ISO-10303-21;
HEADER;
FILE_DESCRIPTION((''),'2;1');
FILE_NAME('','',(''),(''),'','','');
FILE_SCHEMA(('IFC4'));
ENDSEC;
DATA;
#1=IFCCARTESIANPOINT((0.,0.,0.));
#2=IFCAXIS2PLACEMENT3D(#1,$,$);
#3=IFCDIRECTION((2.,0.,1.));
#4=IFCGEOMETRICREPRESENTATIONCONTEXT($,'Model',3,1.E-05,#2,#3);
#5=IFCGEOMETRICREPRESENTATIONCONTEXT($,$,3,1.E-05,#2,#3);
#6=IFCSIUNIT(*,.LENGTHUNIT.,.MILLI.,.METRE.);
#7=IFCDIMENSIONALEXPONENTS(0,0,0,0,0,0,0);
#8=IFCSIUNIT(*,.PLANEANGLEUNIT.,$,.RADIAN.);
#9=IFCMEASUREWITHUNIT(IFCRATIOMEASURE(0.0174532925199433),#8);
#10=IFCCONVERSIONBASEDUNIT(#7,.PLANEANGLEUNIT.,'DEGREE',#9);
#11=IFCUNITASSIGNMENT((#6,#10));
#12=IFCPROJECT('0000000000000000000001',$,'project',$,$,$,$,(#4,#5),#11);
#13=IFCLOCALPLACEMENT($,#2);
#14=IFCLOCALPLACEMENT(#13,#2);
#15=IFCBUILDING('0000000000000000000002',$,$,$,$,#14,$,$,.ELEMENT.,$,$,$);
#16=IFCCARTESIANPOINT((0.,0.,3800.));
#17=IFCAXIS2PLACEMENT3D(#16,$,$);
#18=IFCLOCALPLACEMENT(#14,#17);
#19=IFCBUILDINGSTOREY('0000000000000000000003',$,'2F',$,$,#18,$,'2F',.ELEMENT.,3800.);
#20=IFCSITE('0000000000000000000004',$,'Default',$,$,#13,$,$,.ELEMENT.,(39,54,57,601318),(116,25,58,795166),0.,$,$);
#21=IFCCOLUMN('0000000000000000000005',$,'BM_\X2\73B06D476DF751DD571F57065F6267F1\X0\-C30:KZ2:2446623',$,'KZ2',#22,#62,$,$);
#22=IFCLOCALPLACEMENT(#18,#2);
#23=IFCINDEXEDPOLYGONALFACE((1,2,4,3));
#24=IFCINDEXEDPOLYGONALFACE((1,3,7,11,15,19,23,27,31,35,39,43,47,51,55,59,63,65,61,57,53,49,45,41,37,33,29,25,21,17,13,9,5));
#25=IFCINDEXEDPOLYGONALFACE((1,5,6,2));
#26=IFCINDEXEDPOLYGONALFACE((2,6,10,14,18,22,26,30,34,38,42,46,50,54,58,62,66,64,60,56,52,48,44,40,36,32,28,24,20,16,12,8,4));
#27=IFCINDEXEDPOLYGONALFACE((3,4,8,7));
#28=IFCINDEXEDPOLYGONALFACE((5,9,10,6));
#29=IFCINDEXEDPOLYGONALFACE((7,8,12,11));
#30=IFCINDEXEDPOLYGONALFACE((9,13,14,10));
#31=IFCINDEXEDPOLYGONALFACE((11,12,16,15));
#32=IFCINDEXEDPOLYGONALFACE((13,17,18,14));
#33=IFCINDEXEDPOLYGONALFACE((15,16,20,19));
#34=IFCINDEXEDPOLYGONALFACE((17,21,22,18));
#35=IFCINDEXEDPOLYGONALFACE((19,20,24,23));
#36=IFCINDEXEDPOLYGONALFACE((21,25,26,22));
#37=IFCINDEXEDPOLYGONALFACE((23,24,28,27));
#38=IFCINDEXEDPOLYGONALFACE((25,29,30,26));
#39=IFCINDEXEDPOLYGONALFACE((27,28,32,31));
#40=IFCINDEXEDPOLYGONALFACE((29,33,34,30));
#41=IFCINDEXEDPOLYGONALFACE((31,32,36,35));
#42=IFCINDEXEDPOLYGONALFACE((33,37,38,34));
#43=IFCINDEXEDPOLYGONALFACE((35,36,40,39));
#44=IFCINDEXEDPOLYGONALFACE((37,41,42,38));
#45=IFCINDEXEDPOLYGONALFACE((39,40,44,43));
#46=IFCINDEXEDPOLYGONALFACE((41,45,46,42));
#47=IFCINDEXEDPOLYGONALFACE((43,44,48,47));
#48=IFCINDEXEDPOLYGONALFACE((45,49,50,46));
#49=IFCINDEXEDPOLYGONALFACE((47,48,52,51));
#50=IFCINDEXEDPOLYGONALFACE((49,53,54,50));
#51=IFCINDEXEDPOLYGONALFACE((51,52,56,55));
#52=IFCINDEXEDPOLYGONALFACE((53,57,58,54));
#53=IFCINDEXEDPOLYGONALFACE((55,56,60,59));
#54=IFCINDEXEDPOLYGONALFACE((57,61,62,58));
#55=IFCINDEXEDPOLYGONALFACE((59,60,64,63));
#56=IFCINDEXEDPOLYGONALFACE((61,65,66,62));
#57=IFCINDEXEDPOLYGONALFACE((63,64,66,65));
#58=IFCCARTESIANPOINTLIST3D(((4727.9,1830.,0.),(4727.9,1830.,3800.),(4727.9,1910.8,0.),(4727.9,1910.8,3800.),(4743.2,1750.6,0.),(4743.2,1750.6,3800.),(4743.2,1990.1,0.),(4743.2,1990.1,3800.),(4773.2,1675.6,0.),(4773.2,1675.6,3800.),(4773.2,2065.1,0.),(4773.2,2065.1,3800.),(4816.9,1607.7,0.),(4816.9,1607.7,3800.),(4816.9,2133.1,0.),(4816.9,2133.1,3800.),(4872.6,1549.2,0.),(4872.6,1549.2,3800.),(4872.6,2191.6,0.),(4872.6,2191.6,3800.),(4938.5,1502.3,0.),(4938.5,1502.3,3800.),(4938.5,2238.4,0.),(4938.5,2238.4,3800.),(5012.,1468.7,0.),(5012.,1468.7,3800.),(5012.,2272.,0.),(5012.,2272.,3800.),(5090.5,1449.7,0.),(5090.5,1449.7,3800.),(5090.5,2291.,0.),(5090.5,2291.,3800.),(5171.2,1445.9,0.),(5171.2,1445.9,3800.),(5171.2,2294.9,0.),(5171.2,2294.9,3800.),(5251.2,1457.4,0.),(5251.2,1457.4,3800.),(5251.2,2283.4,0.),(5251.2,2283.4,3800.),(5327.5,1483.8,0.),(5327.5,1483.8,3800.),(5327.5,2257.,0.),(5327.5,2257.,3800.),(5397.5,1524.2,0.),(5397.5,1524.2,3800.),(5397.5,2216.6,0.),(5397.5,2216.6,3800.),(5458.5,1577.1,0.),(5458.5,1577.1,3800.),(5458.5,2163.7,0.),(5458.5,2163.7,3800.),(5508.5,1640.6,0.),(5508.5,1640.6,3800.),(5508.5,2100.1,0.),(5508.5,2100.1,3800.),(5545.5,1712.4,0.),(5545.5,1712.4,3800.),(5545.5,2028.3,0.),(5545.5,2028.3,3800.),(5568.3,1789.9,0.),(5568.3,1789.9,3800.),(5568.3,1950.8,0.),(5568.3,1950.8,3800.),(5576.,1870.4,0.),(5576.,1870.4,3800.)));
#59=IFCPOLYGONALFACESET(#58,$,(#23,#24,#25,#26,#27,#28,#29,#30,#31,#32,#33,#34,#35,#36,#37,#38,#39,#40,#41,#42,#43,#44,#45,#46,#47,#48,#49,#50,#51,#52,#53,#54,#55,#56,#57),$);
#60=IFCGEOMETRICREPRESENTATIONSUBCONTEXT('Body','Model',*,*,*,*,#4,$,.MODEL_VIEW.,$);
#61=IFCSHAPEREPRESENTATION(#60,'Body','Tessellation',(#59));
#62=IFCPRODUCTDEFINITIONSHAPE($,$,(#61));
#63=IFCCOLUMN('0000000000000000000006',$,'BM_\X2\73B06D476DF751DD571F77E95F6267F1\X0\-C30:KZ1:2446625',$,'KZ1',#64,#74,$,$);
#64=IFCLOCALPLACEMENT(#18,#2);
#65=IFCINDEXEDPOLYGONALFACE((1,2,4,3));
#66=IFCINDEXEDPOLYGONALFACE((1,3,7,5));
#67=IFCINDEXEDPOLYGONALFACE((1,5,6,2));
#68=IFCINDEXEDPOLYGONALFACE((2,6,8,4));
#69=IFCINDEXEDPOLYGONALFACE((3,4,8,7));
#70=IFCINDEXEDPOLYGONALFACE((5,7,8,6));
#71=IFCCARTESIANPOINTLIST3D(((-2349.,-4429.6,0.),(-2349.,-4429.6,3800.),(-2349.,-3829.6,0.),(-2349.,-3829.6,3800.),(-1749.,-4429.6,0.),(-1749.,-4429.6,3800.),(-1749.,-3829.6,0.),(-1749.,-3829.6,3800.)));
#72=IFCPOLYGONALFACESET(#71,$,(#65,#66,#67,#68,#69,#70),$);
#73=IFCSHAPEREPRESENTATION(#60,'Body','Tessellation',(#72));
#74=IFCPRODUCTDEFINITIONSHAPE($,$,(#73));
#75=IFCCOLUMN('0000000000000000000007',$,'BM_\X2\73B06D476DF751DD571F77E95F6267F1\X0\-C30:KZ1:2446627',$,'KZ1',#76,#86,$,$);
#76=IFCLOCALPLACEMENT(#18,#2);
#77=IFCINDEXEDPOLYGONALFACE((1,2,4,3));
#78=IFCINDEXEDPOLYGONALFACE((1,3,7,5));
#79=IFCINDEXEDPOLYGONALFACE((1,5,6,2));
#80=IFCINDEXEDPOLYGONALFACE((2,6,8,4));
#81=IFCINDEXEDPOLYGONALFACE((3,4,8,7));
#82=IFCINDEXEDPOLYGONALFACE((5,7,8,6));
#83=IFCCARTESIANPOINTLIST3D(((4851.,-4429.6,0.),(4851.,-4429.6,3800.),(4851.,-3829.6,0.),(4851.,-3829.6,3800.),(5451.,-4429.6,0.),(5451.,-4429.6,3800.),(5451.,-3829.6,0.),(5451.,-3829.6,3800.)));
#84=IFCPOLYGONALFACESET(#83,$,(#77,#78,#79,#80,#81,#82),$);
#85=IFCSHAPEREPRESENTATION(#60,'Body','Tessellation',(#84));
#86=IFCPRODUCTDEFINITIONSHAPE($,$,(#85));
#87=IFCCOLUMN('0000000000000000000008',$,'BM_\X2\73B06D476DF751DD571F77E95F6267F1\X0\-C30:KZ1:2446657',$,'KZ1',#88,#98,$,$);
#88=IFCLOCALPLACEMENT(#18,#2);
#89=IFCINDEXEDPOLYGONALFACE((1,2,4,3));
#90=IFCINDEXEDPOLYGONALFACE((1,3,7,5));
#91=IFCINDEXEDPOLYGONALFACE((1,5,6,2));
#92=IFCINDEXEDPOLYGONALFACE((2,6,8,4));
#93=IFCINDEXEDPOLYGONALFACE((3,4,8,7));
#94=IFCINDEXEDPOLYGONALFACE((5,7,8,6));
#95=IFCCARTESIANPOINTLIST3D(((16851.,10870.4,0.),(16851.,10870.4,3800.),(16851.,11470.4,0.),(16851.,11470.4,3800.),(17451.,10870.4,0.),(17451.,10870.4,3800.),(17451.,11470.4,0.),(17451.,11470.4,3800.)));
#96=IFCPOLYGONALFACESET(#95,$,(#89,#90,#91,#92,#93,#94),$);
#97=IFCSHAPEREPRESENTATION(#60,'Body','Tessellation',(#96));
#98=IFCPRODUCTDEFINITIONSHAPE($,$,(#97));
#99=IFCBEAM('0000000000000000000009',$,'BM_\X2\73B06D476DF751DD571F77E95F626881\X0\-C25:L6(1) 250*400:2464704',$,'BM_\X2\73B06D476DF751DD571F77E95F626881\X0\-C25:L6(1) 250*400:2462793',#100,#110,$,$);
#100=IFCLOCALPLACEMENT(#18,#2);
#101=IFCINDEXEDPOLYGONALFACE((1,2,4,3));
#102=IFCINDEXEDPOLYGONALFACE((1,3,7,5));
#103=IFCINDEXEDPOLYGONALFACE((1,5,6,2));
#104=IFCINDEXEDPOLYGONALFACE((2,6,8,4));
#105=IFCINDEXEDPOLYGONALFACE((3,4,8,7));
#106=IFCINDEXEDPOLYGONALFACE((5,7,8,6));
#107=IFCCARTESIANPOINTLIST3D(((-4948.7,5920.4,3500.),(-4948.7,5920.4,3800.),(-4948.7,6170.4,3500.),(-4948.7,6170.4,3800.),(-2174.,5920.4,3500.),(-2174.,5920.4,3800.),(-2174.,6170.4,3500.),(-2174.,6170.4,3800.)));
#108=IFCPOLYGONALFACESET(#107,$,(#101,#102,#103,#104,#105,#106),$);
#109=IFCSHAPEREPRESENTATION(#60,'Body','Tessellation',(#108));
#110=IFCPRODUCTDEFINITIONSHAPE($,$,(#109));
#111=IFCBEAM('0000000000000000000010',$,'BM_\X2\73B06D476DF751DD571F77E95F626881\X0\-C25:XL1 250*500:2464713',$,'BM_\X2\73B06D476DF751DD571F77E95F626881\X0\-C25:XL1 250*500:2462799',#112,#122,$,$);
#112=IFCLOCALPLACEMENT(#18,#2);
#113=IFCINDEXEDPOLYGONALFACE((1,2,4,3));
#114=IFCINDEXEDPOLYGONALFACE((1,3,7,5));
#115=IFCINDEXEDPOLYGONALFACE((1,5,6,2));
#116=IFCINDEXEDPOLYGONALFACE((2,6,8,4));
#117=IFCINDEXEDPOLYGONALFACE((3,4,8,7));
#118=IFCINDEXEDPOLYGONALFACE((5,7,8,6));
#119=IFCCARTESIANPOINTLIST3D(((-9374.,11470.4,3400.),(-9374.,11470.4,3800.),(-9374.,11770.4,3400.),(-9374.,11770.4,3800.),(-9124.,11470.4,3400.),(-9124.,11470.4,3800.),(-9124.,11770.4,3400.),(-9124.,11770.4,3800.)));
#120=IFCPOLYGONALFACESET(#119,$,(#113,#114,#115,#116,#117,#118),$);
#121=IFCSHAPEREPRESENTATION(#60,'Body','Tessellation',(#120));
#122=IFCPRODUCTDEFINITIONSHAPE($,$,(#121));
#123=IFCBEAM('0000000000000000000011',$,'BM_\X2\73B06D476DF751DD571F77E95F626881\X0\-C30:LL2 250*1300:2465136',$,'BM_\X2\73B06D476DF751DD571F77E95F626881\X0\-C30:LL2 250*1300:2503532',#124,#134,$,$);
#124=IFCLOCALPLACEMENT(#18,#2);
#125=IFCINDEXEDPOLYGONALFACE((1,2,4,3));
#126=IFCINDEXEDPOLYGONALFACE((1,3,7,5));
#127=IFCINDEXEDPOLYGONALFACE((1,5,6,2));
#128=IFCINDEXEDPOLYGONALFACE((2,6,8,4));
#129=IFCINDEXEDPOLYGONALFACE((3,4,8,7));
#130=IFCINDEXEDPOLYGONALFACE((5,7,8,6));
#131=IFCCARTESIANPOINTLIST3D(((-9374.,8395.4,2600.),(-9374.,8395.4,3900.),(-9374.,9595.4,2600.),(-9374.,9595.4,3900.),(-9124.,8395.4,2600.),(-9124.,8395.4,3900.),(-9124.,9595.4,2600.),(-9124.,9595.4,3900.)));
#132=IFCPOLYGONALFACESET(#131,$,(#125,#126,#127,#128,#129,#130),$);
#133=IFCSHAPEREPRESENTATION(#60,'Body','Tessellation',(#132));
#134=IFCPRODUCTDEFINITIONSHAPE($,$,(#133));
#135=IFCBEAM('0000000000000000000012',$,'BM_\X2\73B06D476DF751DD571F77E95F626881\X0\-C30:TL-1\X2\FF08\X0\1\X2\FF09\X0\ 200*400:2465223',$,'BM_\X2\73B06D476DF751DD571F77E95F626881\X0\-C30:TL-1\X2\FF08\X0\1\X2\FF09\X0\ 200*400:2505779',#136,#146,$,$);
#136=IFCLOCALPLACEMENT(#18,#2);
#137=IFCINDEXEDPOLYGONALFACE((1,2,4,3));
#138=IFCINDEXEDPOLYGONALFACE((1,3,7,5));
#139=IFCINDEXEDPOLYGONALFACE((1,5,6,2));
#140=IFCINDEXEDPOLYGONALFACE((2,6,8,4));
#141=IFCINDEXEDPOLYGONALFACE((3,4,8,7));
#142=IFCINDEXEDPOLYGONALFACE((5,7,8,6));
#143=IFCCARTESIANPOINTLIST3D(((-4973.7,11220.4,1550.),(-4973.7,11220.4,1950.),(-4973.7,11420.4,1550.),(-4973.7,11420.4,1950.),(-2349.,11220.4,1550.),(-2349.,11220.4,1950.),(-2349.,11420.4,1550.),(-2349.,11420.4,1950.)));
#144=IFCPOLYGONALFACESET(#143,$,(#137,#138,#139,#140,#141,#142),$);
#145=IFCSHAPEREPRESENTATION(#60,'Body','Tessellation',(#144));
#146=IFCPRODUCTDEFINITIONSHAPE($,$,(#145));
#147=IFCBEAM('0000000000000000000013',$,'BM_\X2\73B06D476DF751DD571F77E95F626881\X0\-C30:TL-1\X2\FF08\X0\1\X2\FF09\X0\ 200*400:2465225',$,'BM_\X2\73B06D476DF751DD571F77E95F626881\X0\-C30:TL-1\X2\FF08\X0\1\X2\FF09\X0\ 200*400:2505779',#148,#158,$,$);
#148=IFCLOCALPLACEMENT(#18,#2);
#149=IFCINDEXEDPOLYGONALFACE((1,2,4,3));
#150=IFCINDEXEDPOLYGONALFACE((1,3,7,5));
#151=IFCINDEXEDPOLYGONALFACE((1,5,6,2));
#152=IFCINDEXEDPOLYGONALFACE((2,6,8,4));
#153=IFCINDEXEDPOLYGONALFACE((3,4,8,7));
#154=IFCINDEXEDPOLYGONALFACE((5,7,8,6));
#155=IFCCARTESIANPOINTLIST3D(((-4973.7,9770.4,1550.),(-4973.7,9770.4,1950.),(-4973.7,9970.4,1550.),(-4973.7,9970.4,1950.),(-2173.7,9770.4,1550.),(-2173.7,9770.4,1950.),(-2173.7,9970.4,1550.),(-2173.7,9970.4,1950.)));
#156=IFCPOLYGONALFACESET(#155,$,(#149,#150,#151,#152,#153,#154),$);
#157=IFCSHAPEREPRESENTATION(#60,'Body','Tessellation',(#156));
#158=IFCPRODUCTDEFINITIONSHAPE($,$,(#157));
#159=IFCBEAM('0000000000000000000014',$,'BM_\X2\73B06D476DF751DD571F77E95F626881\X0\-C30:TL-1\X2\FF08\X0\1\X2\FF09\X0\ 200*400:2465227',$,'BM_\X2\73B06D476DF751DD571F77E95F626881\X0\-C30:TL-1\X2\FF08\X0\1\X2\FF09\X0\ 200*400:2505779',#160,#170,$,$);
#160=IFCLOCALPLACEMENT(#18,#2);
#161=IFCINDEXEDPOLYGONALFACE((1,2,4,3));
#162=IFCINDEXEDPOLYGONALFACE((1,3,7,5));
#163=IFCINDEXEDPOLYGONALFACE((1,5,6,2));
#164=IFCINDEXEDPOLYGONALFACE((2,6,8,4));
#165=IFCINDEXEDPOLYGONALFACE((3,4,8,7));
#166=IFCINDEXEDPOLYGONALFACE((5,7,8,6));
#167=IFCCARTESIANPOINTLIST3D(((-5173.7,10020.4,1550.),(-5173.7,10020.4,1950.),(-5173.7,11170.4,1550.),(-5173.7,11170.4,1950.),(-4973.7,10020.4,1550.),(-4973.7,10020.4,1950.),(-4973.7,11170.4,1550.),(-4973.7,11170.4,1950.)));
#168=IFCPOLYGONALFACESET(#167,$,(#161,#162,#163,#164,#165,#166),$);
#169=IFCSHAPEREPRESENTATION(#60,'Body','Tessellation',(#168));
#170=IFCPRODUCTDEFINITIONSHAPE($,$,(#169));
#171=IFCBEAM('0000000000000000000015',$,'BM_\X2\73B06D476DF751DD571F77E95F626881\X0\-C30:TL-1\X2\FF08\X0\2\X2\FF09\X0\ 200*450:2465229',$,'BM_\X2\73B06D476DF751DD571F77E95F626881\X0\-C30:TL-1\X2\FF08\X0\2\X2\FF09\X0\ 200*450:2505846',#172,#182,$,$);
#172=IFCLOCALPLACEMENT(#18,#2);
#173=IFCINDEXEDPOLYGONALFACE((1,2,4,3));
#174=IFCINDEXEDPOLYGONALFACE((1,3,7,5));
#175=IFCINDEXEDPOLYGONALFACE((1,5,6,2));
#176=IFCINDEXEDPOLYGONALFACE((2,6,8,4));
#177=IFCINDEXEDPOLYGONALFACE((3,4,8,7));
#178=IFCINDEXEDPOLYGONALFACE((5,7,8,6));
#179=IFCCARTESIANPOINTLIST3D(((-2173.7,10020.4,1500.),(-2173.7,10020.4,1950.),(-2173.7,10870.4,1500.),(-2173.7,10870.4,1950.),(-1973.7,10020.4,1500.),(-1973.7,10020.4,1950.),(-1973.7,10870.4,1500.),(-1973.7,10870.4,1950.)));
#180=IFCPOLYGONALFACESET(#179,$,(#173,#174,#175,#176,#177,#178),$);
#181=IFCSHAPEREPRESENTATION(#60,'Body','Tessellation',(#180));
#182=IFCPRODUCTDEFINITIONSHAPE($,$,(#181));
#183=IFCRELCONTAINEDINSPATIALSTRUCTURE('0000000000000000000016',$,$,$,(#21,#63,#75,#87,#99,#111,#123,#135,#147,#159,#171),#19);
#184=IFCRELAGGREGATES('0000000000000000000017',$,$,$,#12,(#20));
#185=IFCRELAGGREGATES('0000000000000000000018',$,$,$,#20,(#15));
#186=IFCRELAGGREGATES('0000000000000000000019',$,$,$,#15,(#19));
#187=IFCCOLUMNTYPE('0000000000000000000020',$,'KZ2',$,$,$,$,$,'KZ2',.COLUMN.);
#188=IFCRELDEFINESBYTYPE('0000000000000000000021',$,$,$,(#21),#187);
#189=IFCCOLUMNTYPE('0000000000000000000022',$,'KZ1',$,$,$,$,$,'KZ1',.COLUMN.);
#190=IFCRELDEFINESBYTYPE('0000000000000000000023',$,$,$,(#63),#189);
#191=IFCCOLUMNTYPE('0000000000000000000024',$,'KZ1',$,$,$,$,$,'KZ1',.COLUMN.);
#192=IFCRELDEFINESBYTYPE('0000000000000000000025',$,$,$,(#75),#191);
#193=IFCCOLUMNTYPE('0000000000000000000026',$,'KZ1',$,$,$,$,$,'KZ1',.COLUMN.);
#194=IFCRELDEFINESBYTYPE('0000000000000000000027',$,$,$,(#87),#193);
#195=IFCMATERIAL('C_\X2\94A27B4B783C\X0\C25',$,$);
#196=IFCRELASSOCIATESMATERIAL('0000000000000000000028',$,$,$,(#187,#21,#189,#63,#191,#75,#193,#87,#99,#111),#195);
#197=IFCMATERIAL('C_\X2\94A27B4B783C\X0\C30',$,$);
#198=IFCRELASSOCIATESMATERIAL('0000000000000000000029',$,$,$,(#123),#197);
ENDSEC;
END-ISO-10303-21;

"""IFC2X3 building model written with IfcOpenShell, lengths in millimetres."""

from ifc_helpers import new_model, entity, si_unit, converted_unit, direction, frame, frame_2d, origin, origin_2d_with_axis, place, context, subcontext, project, spatial, rectangle, circle, extrude, source, transform, mapped, material, type_object, type_shapes, element, save


model = new_model("IFC2X3")

# Units and contexts
model_context = context("Model", 3, precision=1e-05, world=origin(), true_north=direction((2.0, 0.0, 1.0)))
context_of_model = context(None, 3, precision=1e-05, world=origin(), true_north=direction((2.0, 0.0, 1.0)))
body_context = subcontext(model_context, "Body", "Model", "MODEL_VIEW")
ifc_project = project(units=[si_unit("LENGTHUNIT", "METRE", prefix="MILLI"), converted_unit("PLANEANGLEUNIT", "DEGREE", entity("IfcRatioMeasure", 0.0174532925199433), si_unit("PLANEANGLEUNIT", "RADIAN"), dimensions=[0, 0, 0, 0, 0, 0, 0])], contexts=[model_context, context_of_model])

# Site, building, storey
site_placement = place(None, origin())
site = spatial("IfcSite", under=ifc_project, at=site_placement, Name="Default", CompositionType="ELEMENT", RefLatitude=(39, 54, 57, 601318), RefLongitude=(116, 25, 58, 795166), RefElevation=0.0)
building_placement = place(site_placement, origin())
building = spatial("IfcBuilding", under=site, at=building_placement, CompositionType="ELEMENT")
storey_placement = place(building_placement, frame((0.0, 0.0, 3800.0)))
storey = spatial("IfcBuildingStorey", under=building, at=storey_placement, Name="2F", LongName="2F", CompositionType="ELEMENT", Elevation=3800.0)

# Columns
ifc_material_1 = material(Name="C_钢筋砼C25")
column_type_1 = type_object("IfcColumnType", Name="KZ2", ElementType="KZ2", PredefinedType="COLUMN", material=ifc_material_1)
shared_shape_1 = source(origin(), body_context, "Body", "SweptSolid", [
    extrude(circle(Radius=425.0, at=frame_2d((0.0, 0.0), x_axis=(1.0, 0.0))), frame((5151.0, 1870.4, 3800.0)), (0.0, 0.0, 1.0), 3800.0),
])
type_shapes(column_type_1, [shared_shape_1])
column_1_placement = place(storey_placement, frame((0.0, 0.0, -3800.0)))
element("IfcColumn", 1, at=column_1_placement, inside=storey, type_object=column_type_1, material=ifc_material_1, Name="BM_现浇混凝土圆形柱-C30:KZ2:2446623", ObjectType="KZ2", context=body_context, shape_type="MappedRepresentation", body=[
    mapped(shared_shape_1, transform((0.0, 0.0, 0.0), scale=1.0)),
])
column_type_2 = type_object("IfcColumnType", Name="KZ1", ElementType="KZ1", PredefinedType="COLUMN", material=ifc_material_1)
shared_shape_2 = source(origin(), body_context, "Body", "SweptSolid", [
    extrude(rectangle(XDim=600.0, YDim=600.0, at=origin_2d_with_axis()), frame((-2049.0, -4129.6, 3800.0), z_axis=(0.0, 0.0, 1.0), x_axis=(-1.0, 0.0, 0.0)), (0.0, 0.0, 1.0), 3800.0),
])
type_shapes(column_type_2, [shared_shape_2])
column_2_placement = place(storey_placement, frame((0.0, 0.0, -3800.0)))
element("IfcColumn", 2, at=column_2_placement, inside=storey, type_object=column_type_2, material=ifc_material_1, Name="BM_现浇混凝土矩形柱-C30:KZ1:2446625", ObjectType="KZ1", context=body_context, shape_type="MappedRepresentation", body=[
    mapped(shared_shape_2, transform((0.0, 0.0, 0.0), scale=1.0)),
])
column_type_3 = type_object("IfcColumnType", Name="KZ1", ElementType="KZ1", PredefinedType="COLUMN", material=ifc_material_1)
shared_shape_3 = source(origin(), body_context, "Body", "SweptSolid", [
    extrude(rectangle(XDim=600.0, YDim=600.0, at=origin_2d_with_axis()), frame((5151.0, -4129.6, 3800.0), z_axis=(0.0, 0.0, 1.0), x_axis=(-1.0, 0.0, 0.0)), (0.0, 0.0, 1.0), 3800.0),
])
type_shapes(column_type_3, [shared_shape_3])
column_3_placement = place(storey_placement, frame((0.0, 0.0, -3800.0)))
element("IfcColumn", 3, at=column_3_placement, inside=storey, type_object=column_type_3, material=ifc_material_1, Name="BM_现浇混凝土矩形柱-C30:KZ1:2446627", ObjectType="KZ1", context=body_context, shape_type="MappedRepresentation", body=[
    mapped(shared_shape_3, transform((0.0, 0.0, 0.0), scale=1.0)),
])
column_type_4 = type_object("IfcColumnType", Name="KZ1", ElementType="KZ1", PredefinedType="COLUMN", material=ifc_material_1)
shared_shape_4 = source(origin(), body_context, "Body", "SweptSolid", [
    extrude(rectangle(XDim=600.0, YDim=600.0, at=frame_2d((0.0, 0.0), x_axis=(1.0, 0.0))), frame((17151.0, 11170.4, 3800.0), z_axis=(0.0, 0.0, 1.0), x_axis=(-1.0, 0.0, 0.0)), (0.0, 0.0, 1.0), 3800.0),
])
type_shapes(column_type_4, [shared_shape_4])
column_4_placement = place(storey_placement, frame((0.0, 0.0, -3800.0)))
element("IfcColumn", 4, at=column_4_placement, inside=storey, type_object=column_type_4, material=ifc_material_1, Name="BM_现浇混凝土矩形柱-C30:KZ1:2446657", ObjectType="KZ1", context=body_context, shape_type="MappedRepresentation", body=[
    mapped(shared_shape_4, transform((0.0, 0.0, 0.0), scale=1.0)),
])

# Beams
beam_1_placement = place(storey_placement, frame((-5073.7, 6045.4, 3900.0)))
element("IfcBeam", 5, at=beam_1_placement, inside=storey, material=ifc_material_1, Name="BM_现浇混凝土矩形梁-C25:L6(1) 250*400:2464704", ObjectType="BM_现浇混凝土矩形梁-C25:L6(1) 250*400:2462793", context=body_context, shape_type="SweptSolid", body=[
    extrude(rectangle(XDim=300.0, YDim=250.0, at=frame_2d((0.0, 0.0), x_axis=(1.0, 0.0))), frame((125.0, 0.0, -250.0), z_axis=(1.0, 0.0, 0.0), x_axis=(0.0, 0.0, -1.0)), (0.0, 0.0, 1.0), 2774.6),
])
beam_2_placement = place(storey_placement, frame((-9249.0, 11170.4, 3900.0), z_axis=(0.0, 0.0, 1.0), x_axis=(0.0, 1.0, 0.0)))
element("IfcBeam", 6, at=beam_2_placement, inside=storey, material=ifc_material_1, Name="BM_现浇混凝土矩形梁-C25:XL1 250*500:2464713", ObjectType="BM_现浇混凝土矩形梁-C25:XL1 250*500:2462799", context=body_context, shape_type="SweptSolid", body=[
    extrude(rectangle(XDim=400.0, YDim=250.0, at=frame_2d((0.0, 0.0), x_axis=(1.0, 0.0))), frame((300.0, 0.0, -300.0), z_axis=(1.0, 0.0, 0.0), x_axis=(0.0, 0.0, -1.0)), (0.0, 0.0, 1.0), 300.0),
])
ifc_material_2 = material(Name="C_钢筋砼C30")
beam_3_placement = place(storey_placement, frame((-9249.0, 9795.4, 3900.0), z_axis=(0.0, 0.0, 1.0), x_axis=(0.0, -1.0, 0.0)))
element("IfcBeam", 7, at=beam_3_placement, inside=storey, material=ifc_material_2, Name="BM_现浇混凝土矩形梁-C30:LL2 250*1300:2465136", ObjectType="BM_现浇混凝土矩形梁-C30:LL2 250*1300:2503532", context=body_context, shape_type="SweptSolid", body=[
    extrude(rectangle(XDim=1300.0, YDim=250.0, at=frame_2d((0.0, 0.0), x_axis=(1.0, 0.0))), frame((200.0, 0.0, -650.0), z_axis=(1.0, 0.0, 0.0), x_axis=(0.0, 0.0, -1.0)), (0.0, 0.0, 1.0), 1200.0),
])
beam_4_placement = place(storey_placement, frame((-5073.7, 11320.4, 1950.0)))
element("IfcBeam", 8, at=beam_4_placement, inside=storey, Name="BM_现浇混凝土矩形梁-C30:TL-1（1） 200*400:2465223", ObjectType="BM_现浇混凝土矩形梁-C30:TL-1（1） 200*400:2505779", context=body_context, shape_type="SweptSolid", body=[
    extrude(rectangle(XDim=400.0, YDim=200.0, at=frame_2d((0.0, 0.0), x_axis=(1.0, 0.0))), frame((100.0, 0.0, -200.0), z_axis=(1.0, 0.0, 0.0), x_axis=(0.0, 0.0, -1.0)), (0.0, 0.0, 1.0), 2624.6),
])
beam_5_placement = place(storey_placement, frame((-5073.7, 9870.4, 1950.0)))
element("IfcBeam", 9, at=beam_5_placement, inside=storey, Name="BM_现浇混凝土矩形梁-C30:TL-1（1） 200*400:2465225", ObjectType="BM_现浇混凝土矩形梁-C30:TL-1（1） 200*400:2505779", context=body_context, shape_type="SweptSolid", body=[
    extrude(rectangle(XDim=400.0, YDim=200.0, at=frame_2d((0.0, 0.0), x_axis=(1.0, 0.0))), frame((100.0, 0.0, -200.0), z_axis=(1.0, 0.0, 0.0), x_axis=(0.0, 0.0, -1.0)), (0.0, 0.0, 1.0), 2800.0),
])
beam_6_placement = place(storey_placement, frame((-5073.7, 11195.4, 1950.0), z_axis=(0.0, 0.0, 1.0), x_axis=(0.0, -1.0, 0.0)))
element("IfcBeam", 10, at=beam_6_placement, inside=storey, Name="BM_现浇混凝土矩形梁-C30:TL-1（1） 200*400:2465227", ObjectType="BM_现浇混凝土矩形梁-C30:TL-1（1） 200*400:2505779", context=body_context, shape_type="SweptSolid", body=[
    extrude(rectangle(XDim=400.0, YDim=200.0, at=origin_2d_with_axis()), frame((25.0, 0.0, -200.0), z_axis=(1.0, 0.0, 0.0), x_axis=(0.0, 0.0, -1.0)), (0.0, 0.0, 1.0), 1150.0),
])
beam_7_placement = place(storey_placement, frame((-2073.7, 11195.4, 1950.0), z_axis=(0.0, 0.0, 1.0), x_axis=(0.0, -1.0, 0.0)))
element("IfcBeam", 11, at=beam_7_placement, inside=storey, Name="BM_现浇混凝土矩形梁-C30:TL-1（2） 200*450:2465229", ObjectType="BM_现浇混凝土矩形梁-C30:TL-1（2） 200*450:2505846", context=body_context, shape_type="SweptSolid", body=[
    extrude(rectangle(XDim=450.0, YDim=200.0, at=frame_2d((0.0, 0.0), x_axis=(1.0, 0.0))), frame((325.0, 0.0, -225.0), z_axis=(1.0, 0.0, 0.0), x_axis=(0.0, 0.0, -1.0)), (0.0, 0.0, 1.0), 850.0),
])

save(model, "model.ifc")
